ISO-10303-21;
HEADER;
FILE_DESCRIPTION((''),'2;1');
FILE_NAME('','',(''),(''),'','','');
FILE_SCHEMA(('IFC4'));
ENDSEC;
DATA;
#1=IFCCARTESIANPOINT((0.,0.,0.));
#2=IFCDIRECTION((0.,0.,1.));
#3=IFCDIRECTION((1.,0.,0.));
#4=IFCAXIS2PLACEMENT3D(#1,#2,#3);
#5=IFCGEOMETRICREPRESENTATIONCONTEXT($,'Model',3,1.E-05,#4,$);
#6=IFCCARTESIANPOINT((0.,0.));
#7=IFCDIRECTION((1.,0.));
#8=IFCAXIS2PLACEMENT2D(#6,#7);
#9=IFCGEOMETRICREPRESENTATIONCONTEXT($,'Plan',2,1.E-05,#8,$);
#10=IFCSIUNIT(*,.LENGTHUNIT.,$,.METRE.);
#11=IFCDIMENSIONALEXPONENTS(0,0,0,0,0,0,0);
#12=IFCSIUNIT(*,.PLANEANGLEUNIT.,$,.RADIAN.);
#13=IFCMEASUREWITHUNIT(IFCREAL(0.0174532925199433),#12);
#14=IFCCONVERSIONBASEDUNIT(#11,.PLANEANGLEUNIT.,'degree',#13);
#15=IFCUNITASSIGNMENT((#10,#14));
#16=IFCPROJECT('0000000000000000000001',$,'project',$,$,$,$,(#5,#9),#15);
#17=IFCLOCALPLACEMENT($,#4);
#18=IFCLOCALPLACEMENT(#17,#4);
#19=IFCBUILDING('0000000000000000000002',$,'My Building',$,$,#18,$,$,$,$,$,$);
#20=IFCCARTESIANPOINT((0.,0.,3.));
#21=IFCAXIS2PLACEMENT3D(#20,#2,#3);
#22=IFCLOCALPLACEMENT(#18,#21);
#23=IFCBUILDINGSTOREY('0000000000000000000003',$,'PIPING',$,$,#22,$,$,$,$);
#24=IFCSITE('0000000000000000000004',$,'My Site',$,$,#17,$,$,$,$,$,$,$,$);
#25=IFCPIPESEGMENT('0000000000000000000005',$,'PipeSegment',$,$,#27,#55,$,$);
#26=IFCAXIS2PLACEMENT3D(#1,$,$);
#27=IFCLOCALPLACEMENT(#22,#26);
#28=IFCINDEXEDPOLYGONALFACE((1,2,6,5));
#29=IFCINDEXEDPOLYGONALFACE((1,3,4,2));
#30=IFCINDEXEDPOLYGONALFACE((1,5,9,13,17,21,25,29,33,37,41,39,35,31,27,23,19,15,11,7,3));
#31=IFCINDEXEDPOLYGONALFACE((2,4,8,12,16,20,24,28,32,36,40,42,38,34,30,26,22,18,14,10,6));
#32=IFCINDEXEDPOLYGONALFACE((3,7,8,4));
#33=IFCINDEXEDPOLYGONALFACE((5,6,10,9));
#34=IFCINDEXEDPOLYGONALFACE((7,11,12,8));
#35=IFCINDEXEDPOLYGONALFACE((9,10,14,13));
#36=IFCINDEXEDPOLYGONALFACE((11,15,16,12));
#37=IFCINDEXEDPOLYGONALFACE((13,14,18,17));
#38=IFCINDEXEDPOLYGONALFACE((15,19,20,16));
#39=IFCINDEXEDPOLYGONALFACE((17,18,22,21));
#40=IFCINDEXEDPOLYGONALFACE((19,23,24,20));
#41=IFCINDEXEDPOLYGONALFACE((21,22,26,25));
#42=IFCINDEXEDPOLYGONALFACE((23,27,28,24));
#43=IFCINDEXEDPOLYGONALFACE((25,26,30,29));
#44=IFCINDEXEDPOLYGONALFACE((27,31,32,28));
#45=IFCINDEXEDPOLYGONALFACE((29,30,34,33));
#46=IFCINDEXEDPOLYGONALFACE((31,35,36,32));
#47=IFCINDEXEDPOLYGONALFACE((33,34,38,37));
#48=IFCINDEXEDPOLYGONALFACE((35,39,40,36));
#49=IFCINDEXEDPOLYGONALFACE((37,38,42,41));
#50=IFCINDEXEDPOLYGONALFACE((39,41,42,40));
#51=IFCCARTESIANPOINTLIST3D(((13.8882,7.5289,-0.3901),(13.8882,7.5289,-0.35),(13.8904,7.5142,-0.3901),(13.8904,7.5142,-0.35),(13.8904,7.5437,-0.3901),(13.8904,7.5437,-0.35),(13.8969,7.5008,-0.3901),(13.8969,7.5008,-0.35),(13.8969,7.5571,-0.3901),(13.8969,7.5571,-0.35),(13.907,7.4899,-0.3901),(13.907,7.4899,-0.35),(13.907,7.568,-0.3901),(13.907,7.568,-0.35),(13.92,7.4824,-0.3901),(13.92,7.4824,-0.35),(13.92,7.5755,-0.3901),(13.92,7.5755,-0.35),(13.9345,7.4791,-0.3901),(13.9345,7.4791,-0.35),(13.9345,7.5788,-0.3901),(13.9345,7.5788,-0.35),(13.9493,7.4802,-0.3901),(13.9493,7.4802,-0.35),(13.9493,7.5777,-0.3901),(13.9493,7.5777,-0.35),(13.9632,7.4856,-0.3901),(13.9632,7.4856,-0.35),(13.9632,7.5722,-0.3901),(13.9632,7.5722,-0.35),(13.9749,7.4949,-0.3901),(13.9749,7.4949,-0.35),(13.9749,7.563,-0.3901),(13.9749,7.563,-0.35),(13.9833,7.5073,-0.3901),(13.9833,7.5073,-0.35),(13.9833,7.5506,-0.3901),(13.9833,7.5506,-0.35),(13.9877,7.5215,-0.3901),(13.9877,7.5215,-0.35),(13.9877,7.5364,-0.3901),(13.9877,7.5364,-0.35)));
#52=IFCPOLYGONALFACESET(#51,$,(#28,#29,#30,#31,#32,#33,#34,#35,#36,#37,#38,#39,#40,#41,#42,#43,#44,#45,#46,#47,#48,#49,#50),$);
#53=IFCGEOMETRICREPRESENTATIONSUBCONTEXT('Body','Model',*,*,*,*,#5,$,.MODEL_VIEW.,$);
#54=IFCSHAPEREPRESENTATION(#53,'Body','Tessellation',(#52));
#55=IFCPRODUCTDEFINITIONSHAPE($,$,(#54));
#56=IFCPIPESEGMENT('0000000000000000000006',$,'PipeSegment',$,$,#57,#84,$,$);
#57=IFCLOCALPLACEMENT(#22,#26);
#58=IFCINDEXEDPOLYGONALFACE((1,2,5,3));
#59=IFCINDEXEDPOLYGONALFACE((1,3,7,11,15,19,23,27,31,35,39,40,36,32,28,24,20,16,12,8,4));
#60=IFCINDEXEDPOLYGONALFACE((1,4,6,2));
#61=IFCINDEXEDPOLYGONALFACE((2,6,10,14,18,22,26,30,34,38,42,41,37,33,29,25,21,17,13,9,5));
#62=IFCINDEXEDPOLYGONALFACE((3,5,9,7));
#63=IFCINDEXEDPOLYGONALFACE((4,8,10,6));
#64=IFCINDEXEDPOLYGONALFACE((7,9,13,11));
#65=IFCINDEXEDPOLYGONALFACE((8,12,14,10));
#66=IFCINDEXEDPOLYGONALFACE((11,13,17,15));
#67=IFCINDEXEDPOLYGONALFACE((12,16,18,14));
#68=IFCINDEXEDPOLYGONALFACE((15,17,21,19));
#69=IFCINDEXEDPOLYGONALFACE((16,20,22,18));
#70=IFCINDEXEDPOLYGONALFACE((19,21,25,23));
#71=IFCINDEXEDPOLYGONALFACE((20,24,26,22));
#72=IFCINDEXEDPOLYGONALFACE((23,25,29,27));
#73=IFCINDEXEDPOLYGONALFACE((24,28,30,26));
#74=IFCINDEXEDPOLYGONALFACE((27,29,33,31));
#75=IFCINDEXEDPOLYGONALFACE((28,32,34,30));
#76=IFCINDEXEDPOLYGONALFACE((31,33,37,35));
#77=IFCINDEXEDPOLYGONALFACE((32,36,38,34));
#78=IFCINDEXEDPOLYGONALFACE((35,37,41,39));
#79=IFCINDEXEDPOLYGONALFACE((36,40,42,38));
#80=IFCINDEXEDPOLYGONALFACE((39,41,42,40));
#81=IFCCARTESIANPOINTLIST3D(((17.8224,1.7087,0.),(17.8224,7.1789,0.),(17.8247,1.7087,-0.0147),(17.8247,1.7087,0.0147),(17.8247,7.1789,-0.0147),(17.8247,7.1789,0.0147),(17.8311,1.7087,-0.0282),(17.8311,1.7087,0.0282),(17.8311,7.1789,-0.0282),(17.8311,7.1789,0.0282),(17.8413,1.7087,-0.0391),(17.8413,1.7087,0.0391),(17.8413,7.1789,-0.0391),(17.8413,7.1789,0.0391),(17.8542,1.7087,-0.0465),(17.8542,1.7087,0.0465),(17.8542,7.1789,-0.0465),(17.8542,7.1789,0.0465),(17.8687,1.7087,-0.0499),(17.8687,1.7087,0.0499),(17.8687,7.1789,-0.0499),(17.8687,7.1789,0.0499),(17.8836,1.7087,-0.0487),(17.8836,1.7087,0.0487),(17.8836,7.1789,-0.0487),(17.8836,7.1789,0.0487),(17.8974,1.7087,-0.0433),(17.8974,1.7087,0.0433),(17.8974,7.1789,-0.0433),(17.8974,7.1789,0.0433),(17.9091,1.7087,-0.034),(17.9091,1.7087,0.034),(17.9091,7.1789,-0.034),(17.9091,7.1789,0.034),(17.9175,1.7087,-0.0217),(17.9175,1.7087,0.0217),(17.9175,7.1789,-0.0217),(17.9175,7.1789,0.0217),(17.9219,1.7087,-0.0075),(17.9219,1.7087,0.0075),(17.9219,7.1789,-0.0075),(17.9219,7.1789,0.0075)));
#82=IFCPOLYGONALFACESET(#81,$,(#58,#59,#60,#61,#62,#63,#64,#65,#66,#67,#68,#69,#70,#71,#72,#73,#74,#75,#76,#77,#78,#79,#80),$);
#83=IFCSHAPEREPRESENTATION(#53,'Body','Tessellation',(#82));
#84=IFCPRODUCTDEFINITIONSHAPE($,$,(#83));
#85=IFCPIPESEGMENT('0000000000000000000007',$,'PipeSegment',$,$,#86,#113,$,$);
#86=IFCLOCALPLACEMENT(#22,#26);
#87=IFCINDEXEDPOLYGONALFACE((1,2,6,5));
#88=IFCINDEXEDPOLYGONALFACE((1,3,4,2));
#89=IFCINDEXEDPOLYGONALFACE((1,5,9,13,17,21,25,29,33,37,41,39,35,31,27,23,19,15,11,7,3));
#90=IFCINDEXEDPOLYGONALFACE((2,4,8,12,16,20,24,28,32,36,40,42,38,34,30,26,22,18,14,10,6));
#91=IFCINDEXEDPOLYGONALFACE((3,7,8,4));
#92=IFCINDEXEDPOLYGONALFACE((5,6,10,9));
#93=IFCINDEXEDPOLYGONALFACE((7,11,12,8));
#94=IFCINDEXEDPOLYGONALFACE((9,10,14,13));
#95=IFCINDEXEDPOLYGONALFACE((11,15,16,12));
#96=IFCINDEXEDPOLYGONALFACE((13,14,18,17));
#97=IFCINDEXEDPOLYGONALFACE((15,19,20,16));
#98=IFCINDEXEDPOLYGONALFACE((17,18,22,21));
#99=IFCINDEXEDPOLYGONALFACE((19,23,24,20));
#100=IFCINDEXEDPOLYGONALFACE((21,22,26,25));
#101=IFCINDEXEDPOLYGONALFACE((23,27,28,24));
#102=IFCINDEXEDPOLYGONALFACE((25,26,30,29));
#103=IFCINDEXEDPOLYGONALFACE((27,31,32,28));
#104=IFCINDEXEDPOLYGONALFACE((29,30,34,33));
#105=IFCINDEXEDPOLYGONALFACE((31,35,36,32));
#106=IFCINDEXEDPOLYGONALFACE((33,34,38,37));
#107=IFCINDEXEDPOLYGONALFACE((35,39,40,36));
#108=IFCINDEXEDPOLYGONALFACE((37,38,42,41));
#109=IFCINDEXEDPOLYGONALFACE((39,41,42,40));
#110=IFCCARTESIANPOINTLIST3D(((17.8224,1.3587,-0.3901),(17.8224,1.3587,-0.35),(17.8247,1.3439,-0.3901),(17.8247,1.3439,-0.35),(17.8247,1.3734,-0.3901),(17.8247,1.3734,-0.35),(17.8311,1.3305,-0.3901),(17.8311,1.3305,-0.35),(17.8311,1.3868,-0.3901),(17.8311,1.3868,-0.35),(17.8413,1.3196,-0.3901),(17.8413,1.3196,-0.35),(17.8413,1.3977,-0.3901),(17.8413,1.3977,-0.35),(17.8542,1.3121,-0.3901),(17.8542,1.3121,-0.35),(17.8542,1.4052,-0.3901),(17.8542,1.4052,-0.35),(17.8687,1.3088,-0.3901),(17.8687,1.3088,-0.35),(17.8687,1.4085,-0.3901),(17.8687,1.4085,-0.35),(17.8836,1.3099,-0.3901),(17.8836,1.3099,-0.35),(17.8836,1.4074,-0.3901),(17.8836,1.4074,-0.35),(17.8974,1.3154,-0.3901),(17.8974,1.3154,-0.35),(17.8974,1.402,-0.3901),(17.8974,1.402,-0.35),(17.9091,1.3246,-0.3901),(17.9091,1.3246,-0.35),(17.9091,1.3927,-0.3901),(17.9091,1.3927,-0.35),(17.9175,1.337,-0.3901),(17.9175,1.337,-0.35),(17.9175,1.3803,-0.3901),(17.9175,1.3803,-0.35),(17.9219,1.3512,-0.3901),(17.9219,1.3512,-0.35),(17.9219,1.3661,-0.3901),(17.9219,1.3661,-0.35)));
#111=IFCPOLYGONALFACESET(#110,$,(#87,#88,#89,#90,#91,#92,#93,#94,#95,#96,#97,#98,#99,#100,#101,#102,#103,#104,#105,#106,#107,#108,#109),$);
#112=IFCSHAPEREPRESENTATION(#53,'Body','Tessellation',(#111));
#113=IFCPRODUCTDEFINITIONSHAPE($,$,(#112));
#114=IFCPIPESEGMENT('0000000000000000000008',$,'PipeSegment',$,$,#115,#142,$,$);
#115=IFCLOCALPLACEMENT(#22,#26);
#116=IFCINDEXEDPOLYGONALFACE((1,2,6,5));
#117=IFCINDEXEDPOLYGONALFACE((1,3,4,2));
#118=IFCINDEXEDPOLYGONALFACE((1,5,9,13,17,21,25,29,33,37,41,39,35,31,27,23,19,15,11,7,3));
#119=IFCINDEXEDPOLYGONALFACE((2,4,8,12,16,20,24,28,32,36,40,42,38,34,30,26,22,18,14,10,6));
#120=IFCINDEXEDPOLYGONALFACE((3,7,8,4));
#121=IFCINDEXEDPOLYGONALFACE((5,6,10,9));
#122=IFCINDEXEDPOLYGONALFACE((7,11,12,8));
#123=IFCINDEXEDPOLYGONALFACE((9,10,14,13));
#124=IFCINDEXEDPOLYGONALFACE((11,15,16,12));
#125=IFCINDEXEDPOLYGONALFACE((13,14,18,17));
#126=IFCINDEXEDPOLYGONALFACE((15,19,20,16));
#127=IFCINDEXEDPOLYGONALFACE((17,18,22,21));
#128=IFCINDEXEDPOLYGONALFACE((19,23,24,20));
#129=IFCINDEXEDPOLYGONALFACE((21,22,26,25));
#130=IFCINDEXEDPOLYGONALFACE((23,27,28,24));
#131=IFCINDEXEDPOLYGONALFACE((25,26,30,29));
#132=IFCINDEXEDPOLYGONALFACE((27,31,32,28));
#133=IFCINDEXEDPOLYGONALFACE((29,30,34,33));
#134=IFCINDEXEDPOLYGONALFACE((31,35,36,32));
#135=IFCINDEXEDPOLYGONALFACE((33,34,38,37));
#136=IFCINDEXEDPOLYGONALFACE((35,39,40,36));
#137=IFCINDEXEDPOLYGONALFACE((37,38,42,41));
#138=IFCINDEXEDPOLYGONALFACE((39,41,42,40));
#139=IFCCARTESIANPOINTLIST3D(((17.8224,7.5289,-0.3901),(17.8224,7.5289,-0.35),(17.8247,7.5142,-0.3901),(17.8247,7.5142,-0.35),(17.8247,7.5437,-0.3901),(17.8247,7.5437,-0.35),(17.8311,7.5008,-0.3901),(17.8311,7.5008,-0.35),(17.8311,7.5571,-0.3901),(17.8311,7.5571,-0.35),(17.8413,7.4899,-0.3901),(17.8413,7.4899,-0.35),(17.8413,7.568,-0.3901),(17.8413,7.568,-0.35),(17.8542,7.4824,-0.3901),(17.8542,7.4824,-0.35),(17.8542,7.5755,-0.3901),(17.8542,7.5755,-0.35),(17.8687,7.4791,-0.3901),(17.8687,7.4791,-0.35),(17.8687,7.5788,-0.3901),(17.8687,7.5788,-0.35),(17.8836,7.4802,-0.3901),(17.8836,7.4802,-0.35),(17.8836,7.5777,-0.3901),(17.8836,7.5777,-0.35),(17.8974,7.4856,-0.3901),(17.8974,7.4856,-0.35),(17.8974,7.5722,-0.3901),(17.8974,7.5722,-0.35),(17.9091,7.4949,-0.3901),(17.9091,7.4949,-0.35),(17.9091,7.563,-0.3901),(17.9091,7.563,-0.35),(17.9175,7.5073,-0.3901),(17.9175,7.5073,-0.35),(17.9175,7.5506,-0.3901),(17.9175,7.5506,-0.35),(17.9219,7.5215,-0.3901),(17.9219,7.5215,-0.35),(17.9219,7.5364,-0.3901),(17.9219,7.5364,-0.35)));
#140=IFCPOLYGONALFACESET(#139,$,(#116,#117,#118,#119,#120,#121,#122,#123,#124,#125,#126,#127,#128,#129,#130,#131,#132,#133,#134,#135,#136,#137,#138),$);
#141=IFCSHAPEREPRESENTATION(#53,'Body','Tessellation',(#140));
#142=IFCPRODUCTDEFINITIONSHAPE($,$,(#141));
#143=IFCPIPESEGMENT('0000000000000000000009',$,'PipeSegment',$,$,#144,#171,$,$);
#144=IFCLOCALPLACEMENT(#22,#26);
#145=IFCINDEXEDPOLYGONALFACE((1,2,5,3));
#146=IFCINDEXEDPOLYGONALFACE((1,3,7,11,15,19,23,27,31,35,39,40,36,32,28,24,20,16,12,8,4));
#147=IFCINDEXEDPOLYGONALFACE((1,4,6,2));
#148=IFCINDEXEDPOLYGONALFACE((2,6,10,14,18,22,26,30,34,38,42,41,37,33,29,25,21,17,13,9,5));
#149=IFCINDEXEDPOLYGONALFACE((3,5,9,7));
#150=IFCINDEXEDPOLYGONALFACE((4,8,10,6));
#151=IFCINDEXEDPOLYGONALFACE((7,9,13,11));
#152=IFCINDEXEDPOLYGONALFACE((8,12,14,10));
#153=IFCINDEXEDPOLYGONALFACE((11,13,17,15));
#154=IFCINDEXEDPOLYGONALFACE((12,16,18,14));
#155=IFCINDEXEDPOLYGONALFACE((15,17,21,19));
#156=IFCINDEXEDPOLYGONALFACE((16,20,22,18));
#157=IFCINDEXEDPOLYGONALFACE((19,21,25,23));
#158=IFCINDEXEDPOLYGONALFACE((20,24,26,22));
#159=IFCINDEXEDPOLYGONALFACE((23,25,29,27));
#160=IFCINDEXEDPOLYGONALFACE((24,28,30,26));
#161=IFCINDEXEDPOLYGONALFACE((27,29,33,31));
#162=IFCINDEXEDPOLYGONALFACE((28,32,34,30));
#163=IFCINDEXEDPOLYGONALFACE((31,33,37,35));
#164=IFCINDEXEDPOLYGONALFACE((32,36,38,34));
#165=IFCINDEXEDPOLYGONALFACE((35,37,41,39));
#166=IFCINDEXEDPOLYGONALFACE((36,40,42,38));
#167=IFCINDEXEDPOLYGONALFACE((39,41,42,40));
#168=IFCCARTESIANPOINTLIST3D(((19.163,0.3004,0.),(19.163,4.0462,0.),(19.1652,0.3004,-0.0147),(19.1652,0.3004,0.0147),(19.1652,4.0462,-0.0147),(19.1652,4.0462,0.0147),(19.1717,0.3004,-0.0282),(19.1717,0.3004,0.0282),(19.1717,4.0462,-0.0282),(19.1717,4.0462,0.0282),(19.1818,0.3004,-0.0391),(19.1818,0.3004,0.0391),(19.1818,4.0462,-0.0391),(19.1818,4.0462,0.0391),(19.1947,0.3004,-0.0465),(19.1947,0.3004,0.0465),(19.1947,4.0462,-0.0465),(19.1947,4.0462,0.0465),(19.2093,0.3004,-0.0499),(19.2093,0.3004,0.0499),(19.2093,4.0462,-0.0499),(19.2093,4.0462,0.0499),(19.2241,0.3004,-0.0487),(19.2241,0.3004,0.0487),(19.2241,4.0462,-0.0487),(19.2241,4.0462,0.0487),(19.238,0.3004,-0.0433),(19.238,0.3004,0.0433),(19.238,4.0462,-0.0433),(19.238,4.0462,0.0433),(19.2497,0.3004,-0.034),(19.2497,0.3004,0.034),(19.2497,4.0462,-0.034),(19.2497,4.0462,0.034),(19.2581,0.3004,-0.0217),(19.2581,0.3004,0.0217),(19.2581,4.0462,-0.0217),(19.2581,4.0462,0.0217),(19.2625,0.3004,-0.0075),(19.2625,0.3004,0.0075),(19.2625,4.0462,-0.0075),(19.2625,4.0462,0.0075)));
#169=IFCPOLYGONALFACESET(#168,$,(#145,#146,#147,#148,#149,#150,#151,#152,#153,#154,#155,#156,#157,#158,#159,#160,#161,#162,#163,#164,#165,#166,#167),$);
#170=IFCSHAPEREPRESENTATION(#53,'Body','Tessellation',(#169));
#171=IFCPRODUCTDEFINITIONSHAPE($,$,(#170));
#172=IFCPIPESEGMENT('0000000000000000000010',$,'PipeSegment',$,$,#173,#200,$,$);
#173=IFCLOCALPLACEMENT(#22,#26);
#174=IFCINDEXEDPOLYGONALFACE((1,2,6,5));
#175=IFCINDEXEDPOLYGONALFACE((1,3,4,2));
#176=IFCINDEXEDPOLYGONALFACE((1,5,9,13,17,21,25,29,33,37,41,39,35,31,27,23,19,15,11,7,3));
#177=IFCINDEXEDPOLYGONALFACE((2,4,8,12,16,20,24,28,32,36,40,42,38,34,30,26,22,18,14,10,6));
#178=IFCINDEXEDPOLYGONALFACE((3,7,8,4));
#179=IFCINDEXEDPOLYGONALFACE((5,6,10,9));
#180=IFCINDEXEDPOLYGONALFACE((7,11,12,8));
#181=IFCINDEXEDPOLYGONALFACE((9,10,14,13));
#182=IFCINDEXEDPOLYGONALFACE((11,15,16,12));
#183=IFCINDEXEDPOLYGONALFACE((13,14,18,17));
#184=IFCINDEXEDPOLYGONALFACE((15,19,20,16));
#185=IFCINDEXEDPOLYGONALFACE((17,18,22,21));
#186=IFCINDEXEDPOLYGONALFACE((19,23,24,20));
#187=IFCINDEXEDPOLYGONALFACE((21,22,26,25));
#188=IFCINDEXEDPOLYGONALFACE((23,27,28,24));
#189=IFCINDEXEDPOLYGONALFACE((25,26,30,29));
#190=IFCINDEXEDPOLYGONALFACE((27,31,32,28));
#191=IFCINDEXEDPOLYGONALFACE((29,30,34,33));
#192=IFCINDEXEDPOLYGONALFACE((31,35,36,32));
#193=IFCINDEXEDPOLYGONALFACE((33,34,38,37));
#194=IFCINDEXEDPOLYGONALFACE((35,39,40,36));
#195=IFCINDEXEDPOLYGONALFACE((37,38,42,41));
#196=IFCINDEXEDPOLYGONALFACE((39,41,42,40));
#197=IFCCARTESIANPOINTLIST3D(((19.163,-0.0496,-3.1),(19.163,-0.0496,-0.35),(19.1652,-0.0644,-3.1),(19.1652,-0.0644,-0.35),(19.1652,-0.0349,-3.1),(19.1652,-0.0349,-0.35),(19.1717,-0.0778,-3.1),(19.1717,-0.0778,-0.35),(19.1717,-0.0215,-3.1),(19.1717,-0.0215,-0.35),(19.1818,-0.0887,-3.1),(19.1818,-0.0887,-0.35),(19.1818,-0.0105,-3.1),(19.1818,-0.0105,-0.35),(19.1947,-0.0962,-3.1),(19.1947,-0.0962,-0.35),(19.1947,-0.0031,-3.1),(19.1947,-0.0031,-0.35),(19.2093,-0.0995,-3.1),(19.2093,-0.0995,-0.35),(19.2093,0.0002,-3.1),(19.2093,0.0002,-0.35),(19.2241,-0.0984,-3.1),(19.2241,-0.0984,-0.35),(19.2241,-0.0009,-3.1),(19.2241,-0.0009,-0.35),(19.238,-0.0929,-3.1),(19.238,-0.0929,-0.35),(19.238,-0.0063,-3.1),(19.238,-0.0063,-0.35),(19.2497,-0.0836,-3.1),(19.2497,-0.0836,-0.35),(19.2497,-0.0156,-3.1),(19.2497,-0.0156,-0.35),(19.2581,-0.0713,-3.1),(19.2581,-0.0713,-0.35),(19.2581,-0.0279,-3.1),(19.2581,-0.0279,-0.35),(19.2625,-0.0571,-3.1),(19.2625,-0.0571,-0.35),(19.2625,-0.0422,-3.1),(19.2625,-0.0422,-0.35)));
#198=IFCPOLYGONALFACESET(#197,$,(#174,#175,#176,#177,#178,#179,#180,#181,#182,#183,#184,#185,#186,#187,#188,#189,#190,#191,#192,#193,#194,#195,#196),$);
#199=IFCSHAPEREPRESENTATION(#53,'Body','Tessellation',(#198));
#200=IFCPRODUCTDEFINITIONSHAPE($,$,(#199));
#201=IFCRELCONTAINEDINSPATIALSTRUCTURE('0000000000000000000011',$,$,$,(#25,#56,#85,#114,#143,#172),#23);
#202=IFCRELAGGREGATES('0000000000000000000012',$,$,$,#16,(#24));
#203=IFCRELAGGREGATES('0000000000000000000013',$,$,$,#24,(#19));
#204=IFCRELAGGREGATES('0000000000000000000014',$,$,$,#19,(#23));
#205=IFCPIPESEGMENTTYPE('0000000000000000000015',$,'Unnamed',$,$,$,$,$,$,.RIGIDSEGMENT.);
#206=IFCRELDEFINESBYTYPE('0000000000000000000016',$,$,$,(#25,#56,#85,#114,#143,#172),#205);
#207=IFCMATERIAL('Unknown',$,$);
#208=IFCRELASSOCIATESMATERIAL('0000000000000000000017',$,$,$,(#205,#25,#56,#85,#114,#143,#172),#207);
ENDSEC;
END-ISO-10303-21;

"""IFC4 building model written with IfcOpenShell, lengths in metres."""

from ifc_helpers import new_model, entity, si_unit, converted_unit, frame, origin_with_axes, origin_2d_with_axis, place, context, subcontext, project, spatial, circle, extrude, material, material_profile, profile_set, profile_usage, type_object, element, save


model = new_model("IFC4")

# Units and contexts
model_context = context("Model", 3, precision=1e-05, world=origin_with_axes())
plan_context = context("Plan", 2, precision=1e-05, world=origin_2d_with_axis())
body_context = subcontext(model_context, "Body", "Model", "MODEL_VIEW")
ifc_project = project(units=[si_unit("LENGTHUNIT", "METRE"), converted_unit("PLANEANGLEUNIT", "degree", entity("IfcReal", 0.0174532925199433), si_unit("PLANEANGLEUNIT", "RADIAN"), dimensions=[0, 0, 0, 0, 0, 0, 0])], contexts=[model_context, plan_context])

# Site, building, storey
site_placement = place(None, origin_with_axes())
site = spatial("IfcSite", under=ifc_project, at=site_placement, Name="My Site")
building_placement = place(site_placement, origin_with_axes())
building = spatial("IfcBuilding", under=site, at=building_placement, Name="My Building")
storey_placement = place(building_placement, frame((0.0, 0.0, 3.0), z_axis=(0.0, 0.0, 1.0), x_axis=(1.0, 0.0, 0.0)))
storey = spatial("IfcBuildingStorey", under=building, at=storey_placement, Name="PIPING")

# Pipe segments
ifc_material = material(Name="Unknown")
ifc_material_profile_1 = material_profile(ifc_material, circle(Radius=0.05))
ifc_profile_set_1 = profile_set([ifc_material_profile_1])
pipe_segment_type = type_object("IfcPipeSegmentType", Name="Unnamed", PredefinedType="RIGIDSEGMENT", material=ifc_profile_set_1)
ifc_profile_usage_1 = profile_usage(ifc_profile_set_1, cardinal=5)
pipe_segment_1_placement = place(storey_placement, frame((13.9382, 7.5289, -0.35), z_axis=(0.0, 0.0, -1.0), x_axis=(-1.0, 0.0, 0.0)))
element("IfcPipeSegment", 1, at=pipe_segment_1_placement, inside=storey, type_object=pipe_segment_type, material=ifc_profile_usage_1, Name="PipeSegment", context=body_context, shape_type="SweptSolid", body=[
    extrude(circle(Radius=0.05), origin_with_axes(), (0.0, 0.0, 1.0), 0.0401),
])
ifc_profile_usage_2 = profile_usage(ifc_profile_set_1, cardinal=5)
pipe_segment_2_placement = place(storey_placement, frame((17.8724, 1.7087, 0.0), z_axis=(0.0, 1.0, 0.0), x_axis=(-1.0, 0.0, 0.0)))
element("IfcPipeSegment", 2, at=pipe_segment_2_placement, inside=storey, type_object=pipe_segment_type, material=ifc_profile_usage_2, Name="PipeSegment", context=body_context, shape_type="SweptSolid", body=[
    extrude(circle(Radius=0.05), origin_with_axes(), (0.0, 0.0, 1.0), 5.4703),
])
ifc_profile_usage_3 = profile_usage(ifc_profile_set_1, cardinal=5)
pipe_segment_3_placement = place(storey_placement, frame((17.8724, 1.3587, -0.35), z_axis=(0.0, 0.0, -1.0), x_axis=(-1.0, 0.0, 0.0)))
element("IfcPipeSegment", 3, at=pipe_segment_3_placement, inside=storey, type_object=pipe_segment_type, material=ifc_profile_usage_3, Name="PipeSegment", context=body_context, shape_type="SweptSolid", body=[
    extrude(circle(Radius=0.05), origin_with_axes(), (0.0, 0.0, 1.0), 0.0401),
])
ifc_profile_usage_4 = profile_usage(ifc_profile_set_1, cardinal=5)
pipe_segment_4_placement = place(storey_placement, frame((17.8724, 7.5289, -0.35), z_axis=(0.0, 0.0, -1.0), x_axis=(-1.0, 0.0, 0.0)))
element("IfcPipeSegment", 4, at=pipe_segment_4_placement, inside=storey, type_object=pipe_segment_type, material=ifc_profile_usage_4, Name="PipeSegment", context=body_context, shape_type="SweptSolid", body=[
    extrude(circle(Radius=0.05), origin_with_axes(), (0.0, 0.0, 1.0), 0.0401),
])
ifc_profile_usage_5 = profile_usage(ifc_profile_set_1, cardinal=5)
pipe_segment_5_placement = place(storey_placement, frame((19.213, 0.3004, 0.0), z_axis=(0.0, 1.0, 0.0), x_axis=(-1.0, 0.0, 0.0)))
element("IfcPipeSegment", 5, at=pipe_segment_5_placement, inside=storey, type_object=pipe_segment_type, material=ifc_profile_usage_5, Name="PipeSegment", context=body_context, shape_type="SweptSolid", body=[
    extrude(circle(Radius=0.05), origin_with_axes(), (0.0, 0.0, 1.0), 3.7459),
])
ifc_profile_usage_6 = profile_usage(ifc_profile_set_1, cardinal=5)
pipe_segment_6_placement = place(storey_placement, frame((19.213, -0.0496, -0.35), z_axis=(0.0, 0.0, -1.0), x_axis=(-1.0, 0.0, 0.0)))
element("IfcPipeSegment", 6, at=pipe_segment_6_placement, inside=storey, type_object=pipe_segment_type, material=ifc_profile_usage_6, Name="PipeSegment", context=body_context, shape_type="SweptSolid", body=[
    extrude(circle(Radius=0.05), origin_with_axes(), (0.0, 0.0, 1.0), 2.75),
])

save(model, "model.ifc")
